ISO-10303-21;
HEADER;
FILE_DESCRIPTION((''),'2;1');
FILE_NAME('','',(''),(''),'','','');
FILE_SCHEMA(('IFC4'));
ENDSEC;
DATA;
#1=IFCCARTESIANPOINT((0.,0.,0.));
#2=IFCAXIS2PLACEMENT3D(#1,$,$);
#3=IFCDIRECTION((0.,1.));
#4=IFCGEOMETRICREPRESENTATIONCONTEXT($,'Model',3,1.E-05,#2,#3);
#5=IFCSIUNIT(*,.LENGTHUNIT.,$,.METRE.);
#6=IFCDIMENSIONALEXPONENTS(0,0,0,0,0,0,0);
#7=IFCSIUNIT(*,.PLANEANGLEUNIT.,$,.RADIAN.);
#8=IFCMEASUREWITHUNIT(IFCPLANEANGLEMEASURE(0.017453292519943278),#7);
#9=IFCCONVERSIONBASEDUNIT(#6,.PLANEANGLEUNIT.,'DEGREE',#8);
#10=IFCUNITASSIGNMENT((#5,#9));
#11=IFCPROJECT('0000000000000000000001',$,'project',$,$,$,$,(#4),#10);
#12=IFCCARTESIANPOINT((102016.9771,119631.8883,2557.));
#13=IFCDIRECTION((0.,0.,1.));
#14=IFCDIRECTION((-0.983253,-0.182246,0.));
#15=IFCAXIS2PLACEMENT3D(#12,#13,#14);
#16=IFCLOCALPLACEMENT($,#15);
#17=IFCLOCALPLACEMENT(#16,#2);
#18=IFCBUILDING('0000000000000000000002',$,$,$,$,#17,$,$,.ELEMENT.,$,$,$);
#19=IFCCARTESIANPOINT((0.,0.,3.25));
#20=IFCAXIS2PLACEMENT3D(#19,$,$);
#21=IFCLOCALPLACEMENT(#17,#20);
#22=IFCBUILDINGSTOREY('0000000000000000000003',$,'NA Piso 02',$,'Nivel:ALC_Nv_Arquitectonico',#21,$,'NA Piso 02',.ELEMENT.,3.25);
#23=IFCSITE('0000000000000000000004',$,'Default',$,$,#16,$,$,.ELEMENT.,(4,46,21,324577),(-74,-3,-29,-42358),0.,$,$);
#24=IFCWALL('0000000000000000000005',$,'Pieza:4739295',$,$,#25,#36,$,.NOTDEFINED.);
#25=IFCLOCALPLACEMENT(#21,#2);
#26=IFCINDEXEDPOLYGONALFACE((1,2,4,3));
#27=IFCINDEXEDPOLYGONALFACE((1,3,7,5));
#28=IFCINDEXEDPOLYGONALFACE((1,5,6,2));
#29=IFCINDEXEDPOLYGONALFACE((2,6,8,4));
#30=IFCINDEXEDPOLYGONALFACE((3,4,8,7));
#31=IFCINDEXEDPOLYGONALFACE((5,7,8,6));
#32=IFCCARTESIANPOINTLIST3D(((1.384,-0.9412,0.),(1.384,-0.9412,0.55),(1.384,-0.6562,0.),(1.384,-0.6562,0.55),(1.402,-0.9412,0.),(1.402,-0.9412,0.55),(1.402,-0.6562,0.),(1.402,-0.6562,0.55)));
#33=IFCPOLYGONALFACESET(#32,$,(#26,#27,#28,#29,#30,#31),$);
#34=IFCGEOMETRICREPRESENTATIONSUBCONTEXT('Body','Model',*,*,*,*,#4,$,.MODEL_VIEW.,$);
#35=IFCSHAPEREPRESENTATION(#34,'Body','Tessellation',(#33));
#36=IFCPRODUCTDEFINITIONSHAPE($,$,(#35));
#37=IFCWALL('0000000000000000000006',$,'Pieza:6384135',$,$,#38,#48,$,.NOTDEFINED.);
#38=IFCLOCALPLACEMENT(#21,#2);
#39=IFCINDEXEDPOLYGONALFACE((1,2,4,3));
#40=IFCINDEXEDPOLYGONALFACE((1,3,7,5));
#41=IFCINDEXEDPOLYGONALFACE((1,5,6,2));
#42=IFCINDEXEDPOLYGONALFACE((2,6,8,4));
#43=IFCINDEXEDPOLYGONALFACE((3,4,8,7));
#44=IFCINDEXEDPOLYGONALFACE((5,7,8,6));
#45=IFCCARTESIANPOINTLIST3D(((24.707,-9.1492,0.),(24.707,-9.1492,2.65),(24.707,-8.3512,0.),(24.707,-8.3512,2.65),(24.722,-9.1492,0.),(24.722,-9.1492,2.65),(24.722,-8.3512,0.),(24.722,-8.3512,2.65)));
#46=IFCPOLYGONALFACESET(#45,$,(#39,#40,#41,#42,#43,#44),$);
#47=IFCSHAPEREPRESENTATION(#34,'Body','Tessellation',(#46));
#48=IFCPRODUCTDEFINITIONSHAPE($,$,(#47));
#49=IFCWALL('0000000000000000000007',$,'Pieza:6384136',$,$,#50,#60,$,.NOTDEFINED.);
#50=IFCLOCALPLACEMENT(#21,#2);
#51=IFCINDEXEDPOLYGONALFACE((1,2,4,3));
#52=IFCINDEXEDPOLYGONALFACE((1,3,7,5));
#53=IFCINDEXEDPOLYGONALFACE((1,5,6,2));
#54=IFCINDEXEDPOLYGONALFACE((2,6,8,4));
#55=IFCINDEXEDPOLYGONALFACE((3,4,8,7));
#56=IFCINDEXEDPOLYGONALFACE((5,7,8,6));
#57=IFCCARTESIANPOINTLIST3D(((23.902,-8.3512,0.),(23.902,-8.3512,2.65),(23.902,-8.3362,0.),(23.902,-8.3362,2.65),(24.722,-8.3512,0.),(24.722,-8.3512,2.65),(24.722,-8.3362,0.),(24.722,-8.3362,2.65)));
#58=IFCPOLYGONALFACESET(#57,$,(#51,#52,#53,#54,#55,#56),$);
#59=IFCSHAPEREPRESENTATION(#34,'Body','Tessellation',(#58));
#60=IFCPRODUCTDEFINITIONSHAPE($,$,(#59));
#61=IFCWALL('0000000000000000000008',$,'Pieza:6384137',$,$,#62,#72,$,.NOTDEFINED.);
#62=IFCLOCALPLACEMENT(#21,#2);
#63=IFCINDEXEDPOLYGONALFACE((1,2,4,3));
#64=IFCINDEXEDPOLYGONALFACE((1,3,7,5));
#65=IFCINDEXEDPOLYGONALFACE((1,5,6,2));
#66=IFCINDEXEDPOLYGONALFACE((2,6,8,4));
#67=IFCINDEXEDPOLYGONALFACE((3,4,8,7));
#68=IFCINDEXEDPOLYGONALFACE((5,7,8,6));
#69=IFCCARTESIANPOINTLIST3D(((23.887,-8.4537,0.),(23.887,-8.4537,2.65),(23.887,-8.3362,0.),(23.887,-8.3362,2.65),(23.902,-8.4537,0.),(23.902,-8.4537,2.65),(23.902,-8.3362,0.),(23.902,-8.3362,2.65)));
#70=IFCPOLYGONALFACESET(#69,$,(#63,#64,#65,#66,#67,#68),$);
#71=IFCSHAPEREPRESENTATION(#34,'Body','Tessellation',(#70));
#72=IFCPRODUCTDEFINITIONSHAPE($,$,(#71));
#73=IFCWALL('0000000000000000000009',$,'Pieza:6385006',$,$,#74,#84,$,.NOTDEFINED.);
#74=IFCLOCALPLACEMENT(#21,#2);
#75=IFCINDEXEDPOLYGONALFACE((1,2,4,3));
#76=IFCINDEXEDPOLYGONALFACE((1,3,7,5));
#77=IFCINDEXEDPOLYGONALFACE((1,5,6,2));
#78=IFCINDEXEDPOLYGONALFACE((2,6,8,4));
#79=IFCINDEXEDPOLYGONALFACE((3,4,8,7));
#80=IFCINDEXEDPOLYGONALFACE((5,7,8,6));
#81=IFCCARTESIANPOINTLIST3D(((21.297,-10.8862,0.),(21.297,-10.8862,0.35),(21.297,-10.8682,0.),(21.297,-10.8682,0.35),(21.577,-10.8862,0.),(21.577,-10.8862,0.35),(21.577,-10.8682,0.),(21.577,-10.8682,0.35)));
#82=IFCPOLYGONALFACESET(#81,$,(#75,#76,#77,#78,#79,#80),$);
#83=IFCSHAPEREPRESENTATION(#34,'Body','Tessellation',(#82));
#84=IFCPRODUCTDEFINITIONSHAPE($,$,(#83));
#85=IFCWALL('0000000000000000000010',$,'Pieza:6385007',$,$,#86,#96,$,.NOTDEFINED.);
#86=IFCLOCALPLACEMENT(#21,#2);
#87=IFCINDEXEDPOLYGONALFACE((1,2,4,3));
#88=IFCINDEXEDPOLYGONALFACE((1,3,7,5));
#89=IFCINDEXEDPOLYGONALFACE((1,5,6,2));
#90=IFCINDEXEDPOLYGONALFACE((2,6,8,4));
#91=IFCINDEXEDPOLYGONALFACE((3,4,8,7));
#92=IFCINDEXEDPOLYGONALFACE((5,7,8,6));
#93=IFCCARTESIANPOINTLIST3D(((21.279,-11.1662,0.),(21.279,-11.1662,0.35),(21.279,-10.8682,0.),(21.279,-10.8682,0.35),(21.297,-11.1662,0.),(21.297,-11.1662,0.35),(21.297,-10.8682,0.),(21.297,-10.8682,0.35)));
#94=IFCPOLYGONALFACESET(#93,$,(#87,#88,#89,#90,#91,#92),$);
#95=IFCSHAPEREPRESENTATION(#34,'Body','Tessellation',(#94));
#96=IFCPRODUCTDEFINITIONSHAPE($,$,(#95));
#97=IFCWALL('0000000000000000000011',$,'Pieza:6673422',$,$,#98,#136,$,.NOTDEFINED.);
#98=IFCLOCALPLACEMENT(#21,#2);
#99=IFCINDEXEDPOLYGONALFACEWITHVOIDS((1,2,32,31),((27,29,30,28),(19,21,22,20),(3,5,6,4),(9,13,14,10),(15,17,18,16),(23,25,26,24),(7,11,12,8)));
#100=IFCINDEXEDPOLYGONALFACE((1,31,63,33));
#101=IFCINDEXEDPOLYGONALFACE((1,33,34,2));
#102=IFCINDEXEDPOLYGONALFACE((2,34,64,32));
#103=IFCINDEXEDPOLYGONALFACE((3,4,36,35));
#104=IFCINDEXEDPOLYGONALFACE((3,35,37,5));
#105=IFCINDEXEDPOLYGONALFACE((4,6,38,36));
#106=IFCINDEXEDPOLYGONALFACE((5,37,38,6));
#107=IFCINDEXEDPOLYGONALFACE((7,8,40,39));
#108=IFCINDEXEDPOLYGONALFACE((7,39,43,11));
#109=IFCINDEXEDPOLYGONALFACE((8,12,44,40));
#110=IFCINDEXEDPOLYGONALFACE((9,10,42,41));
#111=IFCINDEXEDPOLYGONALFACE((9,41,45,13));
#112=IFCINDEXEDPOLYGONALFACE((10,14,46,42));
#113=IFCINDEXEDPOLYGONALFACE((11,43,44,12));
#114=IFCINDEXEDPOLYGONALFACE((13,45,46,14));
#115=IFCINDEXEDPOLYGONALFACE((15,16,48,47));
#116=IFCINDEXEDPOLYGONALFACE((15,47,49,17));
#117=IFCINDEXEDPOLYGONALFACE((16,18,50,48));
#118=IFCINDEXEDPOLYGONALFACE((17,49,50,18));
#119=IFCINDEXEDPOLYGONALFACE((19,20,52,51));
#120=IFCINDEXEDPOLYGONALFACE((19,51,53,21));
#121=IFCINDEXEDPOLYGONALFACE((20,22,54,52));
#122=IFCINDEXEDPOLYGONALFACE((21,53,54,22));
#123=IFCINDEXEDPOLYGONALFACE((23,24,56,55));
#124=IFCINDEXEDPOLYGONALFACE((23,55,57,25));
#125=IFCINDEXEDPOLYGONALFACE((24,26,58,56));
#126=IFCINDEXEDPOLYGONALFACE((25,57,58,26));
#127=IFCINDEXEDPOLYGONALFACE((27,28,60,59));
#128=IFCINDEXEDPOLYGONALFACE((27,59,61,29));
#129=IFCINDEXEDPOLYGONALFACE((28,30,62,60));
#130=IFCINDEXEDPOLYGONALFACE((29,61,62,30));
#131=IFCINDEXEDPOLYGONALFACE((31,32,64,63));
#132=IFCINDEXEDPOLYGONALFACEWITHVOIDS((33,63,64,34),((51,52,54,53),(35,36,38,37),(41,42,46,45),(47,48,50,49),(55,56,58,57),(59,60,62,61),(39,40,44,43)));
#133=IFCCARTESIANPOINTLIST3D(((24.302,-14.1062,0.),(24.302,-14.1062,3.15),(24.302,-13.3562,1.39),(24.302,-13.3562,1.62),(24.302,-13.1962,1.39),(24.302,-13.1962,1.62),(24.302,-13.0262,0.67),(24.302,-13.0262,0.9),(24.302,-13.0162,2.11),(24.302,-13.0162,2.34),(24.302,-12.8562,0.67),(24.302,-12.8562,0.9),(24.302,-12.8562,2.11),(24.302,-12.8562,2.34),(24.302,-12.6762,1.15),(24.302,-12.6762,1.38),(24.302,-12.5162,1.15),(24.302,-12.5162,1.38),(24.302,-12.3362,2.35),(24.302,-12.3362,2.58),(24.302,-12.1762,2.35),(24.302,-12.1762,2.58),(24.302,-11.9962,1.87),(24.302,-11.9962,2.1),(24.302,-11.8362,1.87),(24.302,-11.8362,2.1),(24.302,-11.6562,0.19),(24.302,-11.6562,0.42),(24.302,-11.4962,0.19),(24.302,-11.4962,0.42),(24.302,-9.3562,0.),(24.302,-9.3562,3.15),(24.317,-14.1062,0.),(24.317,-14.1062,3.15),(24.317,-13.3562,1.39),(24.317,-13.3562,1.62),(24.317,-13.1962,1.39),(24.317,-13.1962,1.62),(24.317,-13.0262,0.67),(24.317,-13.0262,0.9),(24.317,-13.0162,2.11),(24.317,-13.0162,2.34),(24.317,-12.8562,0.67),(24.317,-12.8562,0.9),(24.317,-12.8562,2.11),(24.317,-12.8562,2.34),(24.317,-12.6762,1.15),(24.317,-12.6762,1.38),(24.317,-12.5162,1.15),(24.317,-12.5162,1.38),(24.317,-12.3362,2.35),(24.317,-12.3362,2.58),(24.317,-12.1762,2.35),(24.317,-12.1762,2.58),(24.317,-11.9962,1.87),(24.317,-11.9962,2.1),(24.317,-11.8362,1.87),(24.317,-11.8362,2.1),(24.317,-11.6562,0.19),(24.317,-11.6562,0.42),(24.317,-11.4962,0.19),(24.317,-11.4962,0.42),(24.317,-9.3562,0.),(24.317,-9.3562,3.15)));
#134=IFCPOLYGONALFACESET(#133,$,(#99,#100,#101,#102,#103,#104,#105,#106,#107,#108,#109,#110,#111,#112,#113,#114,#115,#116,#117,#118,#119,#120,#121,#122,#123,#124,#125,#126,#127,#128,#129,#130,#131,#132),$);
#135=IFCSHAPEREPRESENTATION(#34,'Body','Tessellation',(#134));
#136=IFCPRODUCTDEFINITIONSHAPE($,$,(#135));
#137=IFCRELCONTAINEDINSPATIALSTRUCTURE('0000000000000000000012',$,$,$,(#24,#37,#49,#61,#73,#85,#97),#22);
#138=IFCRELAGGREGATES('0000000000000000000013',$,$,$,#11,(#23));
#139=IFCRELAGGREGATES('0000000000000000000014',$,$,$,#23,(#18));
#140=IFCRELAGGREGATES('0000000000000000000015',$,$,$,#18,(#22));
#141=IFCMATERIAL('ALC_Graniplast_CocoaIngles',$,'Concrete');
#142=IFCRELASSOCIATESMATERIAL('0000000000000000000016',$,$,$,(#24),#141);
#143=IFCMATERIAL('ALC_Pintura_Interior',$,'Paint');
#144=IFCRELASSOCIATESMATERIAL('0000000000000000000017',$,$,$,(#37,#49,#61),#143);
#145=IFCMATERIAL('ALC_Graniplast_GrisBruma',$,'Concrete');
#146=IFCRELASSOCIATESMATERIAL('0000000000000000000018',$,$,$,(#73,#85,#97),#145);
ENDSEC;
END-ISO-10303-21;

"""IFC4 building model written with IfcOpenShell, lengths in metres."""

from ifc_helpers import new_model, entity, si_unit, converted_unit, direction, frame, frame_2d, origin, origin_2d_with_axis, place, context, subcontext, project, spatial, rectangle, extrude, boolean, material, element, save


model = new_model("IFC4")

# Units and contexts
model_context = context("Model", 3, precision=1e-05, world=origin(), true_north=direction((0.0, 1.0)))
body_context = subcontext(model_context, "Body", "Model", "MODEL_VIEW")
ifc_project = project(units=[si_unit("LENGTHUNIT", "METRE"), converted_unit("PLANEANGLEUNIT", "DEGREE", entity("IfcPlaneAngleMeasure", 0.017453292519943278), si_unit("PLANEANGLEUNIT", "RADIAN"), dimensions=[0, 0, 0, 0, 0, 0, 0])], contexts=[model_context])

# Site, building, storey
site_placement = place(None, frame((102016.9771, 119631.8883, 2557.0), z_axis=(0.0, 0.0, 1.0), x_axis=(-0.983253, -0.182246, 0.0)))
site = spatial("IfcSite", under=ifc_project, at=site_placement, Name="Default", CompositionType="ELEMENT", RefLatitude=(4, 46, 21, 324577), RefLongitude=(-74, -3, -29, -42358), RefElevation=0.0)
building_placement = place(site_placement, origin())
building = spatial("IfcBuilding", under=site, at=building_placement, CompositionType="ELEMENT")
storey_placement = place(building_placement, frame((0.0, 0.0, 3.25)))
storey = spatial("IfcBuildingStorey", under=building, at=storey_placement, Name="NA Piso 02", ObjectType="Nivel:ALC_Nv_Arquitectonico", LongName="NA Piso 02", CompositionType="ELEMENT", Elevation=3.25)

# Walls
ifc_material_1 = material(Name="ALC_Graniplast_CocoaIngles", Category="Concrete")
wall_1_placement = place(storey_placement, frame((0.0, 0.0, -0.55)))
element("IfcWall", 1, at=wall_1_placement, inside=storey, material=ifc_material_1, Name="Pieza:4739295", PredefinedType="NOTDEFINED", context=body_context, shape_type="SweptSolid", body=[
    extrude(rectangle(XDim=0.285, YDim=0.018, at=frame_2d((0.0, 0.0), x_axis=(1.0, 0.0))), frame((1.393, -0.7987, 0.55), z_axis=(0.0, 0.0, 1.0), x_axis=(0.0, -1.0, 0.0)), (0.0, 0.0, 1.0), 0.55),
])
ifc_material_2 = material(Name="ALC_Pintura_Interior", Category="Paint")
wall_2_placement = place(storey_placement, origin())
element("IfcWall", 2, at=wall_2_placement, inside=storey, material=ifc_material_2, Name="Pieza:6384135", PredefinedType="NOTDEFINED", context=body_context, shape_type="SweptSolid", body=[
    extrude(rectangle(XDim=0.798, YDim=0.015, at=frame_2d((0.0, 0.0), x_axis=(1.0, 0.0))), frame((24.7145, -8.7502, 0.0), z_axis=(0.0, 0.0, 1.0), x_axis=(0.0, -1.0, 0.0)), (0.0, 0.0, 1.0), 2.65),
])
wall_3_placement = place(storey_placement, origin())
element("IfcWall", 3, at=wall_3_placement, inside=storey, material=ifc_material_2, Name="Pieza:6384136", PredefinedType="NOTDEFINED", context=body_context, shape_type="SweptSolid", body=[
    extrude(rectangle(XDim=0.015, YDim=0.82, at=origin_2d_with_axis()), frame((24.312, -8.3437, 0.0), z_axis=(0.0, 0.0, 1.0), x_axis=(0.0, -1.0, 0.0)), (0.0, 0.0, 1.0), 2.65),
])
wall_4_placement = place(storey_placement, origin())
element("IfcWall", 4, at=wall_4_placement, inside=storey, material=ifc_material_2, Name="Pieza:6384137", PredefinedType="NOTDEFINED", context=body_context, shape_type="SweptSolid", body=[
    extrude(rectangle(XDim=0.1175, YDim=0.015, at=frame_2d((0.0, 0.0), x_axis=(1.0, 0.0))), frame((23.8945, -8.3949, 0.0), z_axis=(0.0, 0.0, 1.0), x_axis=(0.0, -1.0, 0.0)), (0.0, 0.0, 1.0), 2.65),
])
ifc_material_3 = material(Name="ALC_Graniplast_GrisBruma", Category="Concrete")
wall_5_placement = place(storey_placement, origin())
element("IfcWall", 5, at=wall_5_placement, inside=storey, material=ifc_material_3, Name="Pieza:6385006", PredefinedType="NOTDEFINED", context=body_context, shape_type="SweptSolid", body=[
    extrude(rectangle(XDim=0.018, YDim=0.28, at=frame_2d((0.0, 0.0), x_axis=(1.0, 0.0))), frame((21.437, -10.8772, 0.0), z_axis=(0.0, 0.0, 1.0), x_axis=(0.0, -1.0, 0.0)), (0.0, 0.0, 1.0), 0.35),
])
wall_6_placement = place(storey_placement, origin())
element("IfcWall", 6, at=wall_6_placement, inside=storey, material=ifc_material_3, Name="Pieza:6385007", PredefinedType="NOTDEFINED", context=body_context, shape_type="SweptSolid", body=[
    extrude(rectangle(XDim=0.298, YDim=0.018, at=frame_2d((0.0, 0.0), x_axis=(1.0, 0.0))), frame((21.288, -11.0172, 0.0), z_axis=(0.0, 0.0, 1.0), x_axis=(0.0, -1.0, 0.0)), (0.0, 0.0, 1.0), 0.35),
])
wall_7_placement = place(storey_placement, frame((0.0, 0.0, -3.25)))
element("IfcWall", 7, at=wall_7_placement, inside=storey, material=ifc_material_3, Name="Pieza:6673422", PredefinedType="NOTDEFINED", context=body_context, shape_type="SweptSolid", body=[
    boolean("DIFFERENCE", boolean("DIFFERENCE", boolean("DIFFERENCE", boolean("DIFFERENCE", boolean("DIFFERENCE", boolean("DIFFERENCE", boolean("DIFFERENCE", extrude(rectangle(XDim=0.015, YDim=4.75, at=frame_2d((0.0, 0.0), x_axis=(1.0, 0.0))), frame((24.3095, -11.7312, 3.25)), (0.0, 0.0, 1.0), 3.15), extrude(rectangle(XDim=0.23, YDim=0.16, at=frame_2d((0.0, 0.0), x_axis=(0.0, 1.0))), frame((24.302, -11.5762, 3.555), z_axis=(1.0, 0.0, 0.0), x_axis=(0.0, -1.0, 0.0)), (0.0, 0.0, 1.0), 0.015)), extrude(rectangle(XDim=0.23, YDim=0.17, at=frame_2d((0.0, 0.0), x_axis=(0.0, 1.0))), frame((24.302, -12.9412, 4.035), z_axis=(1.0, 0.0, 0.0), x_axis=(0.0, -1.0, 0.0)), (0.0, 0.0, 1.0), 0.015)), extrude(rectangle(XDim=0.23, YDim=0.16, at=frame_2d((0.0, 0.0), x_axis=(0.0, 1.0))), frame((24.302, -12.5962, 4.515), z_axis=(1.0, 0.0, 0.0), x_axis=(0.0, -1.0, 0.0)), (0.0, 0.0, 1.0), 0.015)), extrude(rectangle(XDim=0.23, YDim=0.16, at=frame_2d((0.0, 0.0), x_axis=(0.0, 1.0))), frame((24.302, -13.2762, 4.755), z_axis=(1.0, 0.0, 0.0), x_axis=(0.0, -1.0, 0.0)), (0.0, 0.0, 1.0), 0.015)), extrude(rectangle(XDim=0.23, YDim=0.16, at=frame_2d((0.0, 0.0), x_axis=(0.0, 1.0))), frame((24.302, -11.9162, 5.235), z_axis=(1.0, 0.0, 0.0), x_axis=(0.0, -1.0, 0.0)), (0.0, 0.0, 1.0), 0.015)), extrude(rectangle(XDim=0.23, YDim=0.16, at=frame_2d((0.0, 0.0), x_axis=(0.0, 1.0))), frame((24.302, -12.9362, 5.475), z_axis=(1.0, 0.0, 0.0), x_axis=(0.0, -1.0, 0.0)), (0.0, 0.0, 1.0), 0.015)), extrude(rectangle(XDim=0.23, YDim=0.16, at=frame_2d((0.0, 0.0), x_axis=(0.0, 1.0))), frame((24.302, -12.2562, 5.715), z_axis=(1.0, 0.0, 0.0), x_axis=(0.0, -1.0, 0.0)), (0.0, 0.0, 1.0), 0.015)),
])

save(model, "model.ifc")
